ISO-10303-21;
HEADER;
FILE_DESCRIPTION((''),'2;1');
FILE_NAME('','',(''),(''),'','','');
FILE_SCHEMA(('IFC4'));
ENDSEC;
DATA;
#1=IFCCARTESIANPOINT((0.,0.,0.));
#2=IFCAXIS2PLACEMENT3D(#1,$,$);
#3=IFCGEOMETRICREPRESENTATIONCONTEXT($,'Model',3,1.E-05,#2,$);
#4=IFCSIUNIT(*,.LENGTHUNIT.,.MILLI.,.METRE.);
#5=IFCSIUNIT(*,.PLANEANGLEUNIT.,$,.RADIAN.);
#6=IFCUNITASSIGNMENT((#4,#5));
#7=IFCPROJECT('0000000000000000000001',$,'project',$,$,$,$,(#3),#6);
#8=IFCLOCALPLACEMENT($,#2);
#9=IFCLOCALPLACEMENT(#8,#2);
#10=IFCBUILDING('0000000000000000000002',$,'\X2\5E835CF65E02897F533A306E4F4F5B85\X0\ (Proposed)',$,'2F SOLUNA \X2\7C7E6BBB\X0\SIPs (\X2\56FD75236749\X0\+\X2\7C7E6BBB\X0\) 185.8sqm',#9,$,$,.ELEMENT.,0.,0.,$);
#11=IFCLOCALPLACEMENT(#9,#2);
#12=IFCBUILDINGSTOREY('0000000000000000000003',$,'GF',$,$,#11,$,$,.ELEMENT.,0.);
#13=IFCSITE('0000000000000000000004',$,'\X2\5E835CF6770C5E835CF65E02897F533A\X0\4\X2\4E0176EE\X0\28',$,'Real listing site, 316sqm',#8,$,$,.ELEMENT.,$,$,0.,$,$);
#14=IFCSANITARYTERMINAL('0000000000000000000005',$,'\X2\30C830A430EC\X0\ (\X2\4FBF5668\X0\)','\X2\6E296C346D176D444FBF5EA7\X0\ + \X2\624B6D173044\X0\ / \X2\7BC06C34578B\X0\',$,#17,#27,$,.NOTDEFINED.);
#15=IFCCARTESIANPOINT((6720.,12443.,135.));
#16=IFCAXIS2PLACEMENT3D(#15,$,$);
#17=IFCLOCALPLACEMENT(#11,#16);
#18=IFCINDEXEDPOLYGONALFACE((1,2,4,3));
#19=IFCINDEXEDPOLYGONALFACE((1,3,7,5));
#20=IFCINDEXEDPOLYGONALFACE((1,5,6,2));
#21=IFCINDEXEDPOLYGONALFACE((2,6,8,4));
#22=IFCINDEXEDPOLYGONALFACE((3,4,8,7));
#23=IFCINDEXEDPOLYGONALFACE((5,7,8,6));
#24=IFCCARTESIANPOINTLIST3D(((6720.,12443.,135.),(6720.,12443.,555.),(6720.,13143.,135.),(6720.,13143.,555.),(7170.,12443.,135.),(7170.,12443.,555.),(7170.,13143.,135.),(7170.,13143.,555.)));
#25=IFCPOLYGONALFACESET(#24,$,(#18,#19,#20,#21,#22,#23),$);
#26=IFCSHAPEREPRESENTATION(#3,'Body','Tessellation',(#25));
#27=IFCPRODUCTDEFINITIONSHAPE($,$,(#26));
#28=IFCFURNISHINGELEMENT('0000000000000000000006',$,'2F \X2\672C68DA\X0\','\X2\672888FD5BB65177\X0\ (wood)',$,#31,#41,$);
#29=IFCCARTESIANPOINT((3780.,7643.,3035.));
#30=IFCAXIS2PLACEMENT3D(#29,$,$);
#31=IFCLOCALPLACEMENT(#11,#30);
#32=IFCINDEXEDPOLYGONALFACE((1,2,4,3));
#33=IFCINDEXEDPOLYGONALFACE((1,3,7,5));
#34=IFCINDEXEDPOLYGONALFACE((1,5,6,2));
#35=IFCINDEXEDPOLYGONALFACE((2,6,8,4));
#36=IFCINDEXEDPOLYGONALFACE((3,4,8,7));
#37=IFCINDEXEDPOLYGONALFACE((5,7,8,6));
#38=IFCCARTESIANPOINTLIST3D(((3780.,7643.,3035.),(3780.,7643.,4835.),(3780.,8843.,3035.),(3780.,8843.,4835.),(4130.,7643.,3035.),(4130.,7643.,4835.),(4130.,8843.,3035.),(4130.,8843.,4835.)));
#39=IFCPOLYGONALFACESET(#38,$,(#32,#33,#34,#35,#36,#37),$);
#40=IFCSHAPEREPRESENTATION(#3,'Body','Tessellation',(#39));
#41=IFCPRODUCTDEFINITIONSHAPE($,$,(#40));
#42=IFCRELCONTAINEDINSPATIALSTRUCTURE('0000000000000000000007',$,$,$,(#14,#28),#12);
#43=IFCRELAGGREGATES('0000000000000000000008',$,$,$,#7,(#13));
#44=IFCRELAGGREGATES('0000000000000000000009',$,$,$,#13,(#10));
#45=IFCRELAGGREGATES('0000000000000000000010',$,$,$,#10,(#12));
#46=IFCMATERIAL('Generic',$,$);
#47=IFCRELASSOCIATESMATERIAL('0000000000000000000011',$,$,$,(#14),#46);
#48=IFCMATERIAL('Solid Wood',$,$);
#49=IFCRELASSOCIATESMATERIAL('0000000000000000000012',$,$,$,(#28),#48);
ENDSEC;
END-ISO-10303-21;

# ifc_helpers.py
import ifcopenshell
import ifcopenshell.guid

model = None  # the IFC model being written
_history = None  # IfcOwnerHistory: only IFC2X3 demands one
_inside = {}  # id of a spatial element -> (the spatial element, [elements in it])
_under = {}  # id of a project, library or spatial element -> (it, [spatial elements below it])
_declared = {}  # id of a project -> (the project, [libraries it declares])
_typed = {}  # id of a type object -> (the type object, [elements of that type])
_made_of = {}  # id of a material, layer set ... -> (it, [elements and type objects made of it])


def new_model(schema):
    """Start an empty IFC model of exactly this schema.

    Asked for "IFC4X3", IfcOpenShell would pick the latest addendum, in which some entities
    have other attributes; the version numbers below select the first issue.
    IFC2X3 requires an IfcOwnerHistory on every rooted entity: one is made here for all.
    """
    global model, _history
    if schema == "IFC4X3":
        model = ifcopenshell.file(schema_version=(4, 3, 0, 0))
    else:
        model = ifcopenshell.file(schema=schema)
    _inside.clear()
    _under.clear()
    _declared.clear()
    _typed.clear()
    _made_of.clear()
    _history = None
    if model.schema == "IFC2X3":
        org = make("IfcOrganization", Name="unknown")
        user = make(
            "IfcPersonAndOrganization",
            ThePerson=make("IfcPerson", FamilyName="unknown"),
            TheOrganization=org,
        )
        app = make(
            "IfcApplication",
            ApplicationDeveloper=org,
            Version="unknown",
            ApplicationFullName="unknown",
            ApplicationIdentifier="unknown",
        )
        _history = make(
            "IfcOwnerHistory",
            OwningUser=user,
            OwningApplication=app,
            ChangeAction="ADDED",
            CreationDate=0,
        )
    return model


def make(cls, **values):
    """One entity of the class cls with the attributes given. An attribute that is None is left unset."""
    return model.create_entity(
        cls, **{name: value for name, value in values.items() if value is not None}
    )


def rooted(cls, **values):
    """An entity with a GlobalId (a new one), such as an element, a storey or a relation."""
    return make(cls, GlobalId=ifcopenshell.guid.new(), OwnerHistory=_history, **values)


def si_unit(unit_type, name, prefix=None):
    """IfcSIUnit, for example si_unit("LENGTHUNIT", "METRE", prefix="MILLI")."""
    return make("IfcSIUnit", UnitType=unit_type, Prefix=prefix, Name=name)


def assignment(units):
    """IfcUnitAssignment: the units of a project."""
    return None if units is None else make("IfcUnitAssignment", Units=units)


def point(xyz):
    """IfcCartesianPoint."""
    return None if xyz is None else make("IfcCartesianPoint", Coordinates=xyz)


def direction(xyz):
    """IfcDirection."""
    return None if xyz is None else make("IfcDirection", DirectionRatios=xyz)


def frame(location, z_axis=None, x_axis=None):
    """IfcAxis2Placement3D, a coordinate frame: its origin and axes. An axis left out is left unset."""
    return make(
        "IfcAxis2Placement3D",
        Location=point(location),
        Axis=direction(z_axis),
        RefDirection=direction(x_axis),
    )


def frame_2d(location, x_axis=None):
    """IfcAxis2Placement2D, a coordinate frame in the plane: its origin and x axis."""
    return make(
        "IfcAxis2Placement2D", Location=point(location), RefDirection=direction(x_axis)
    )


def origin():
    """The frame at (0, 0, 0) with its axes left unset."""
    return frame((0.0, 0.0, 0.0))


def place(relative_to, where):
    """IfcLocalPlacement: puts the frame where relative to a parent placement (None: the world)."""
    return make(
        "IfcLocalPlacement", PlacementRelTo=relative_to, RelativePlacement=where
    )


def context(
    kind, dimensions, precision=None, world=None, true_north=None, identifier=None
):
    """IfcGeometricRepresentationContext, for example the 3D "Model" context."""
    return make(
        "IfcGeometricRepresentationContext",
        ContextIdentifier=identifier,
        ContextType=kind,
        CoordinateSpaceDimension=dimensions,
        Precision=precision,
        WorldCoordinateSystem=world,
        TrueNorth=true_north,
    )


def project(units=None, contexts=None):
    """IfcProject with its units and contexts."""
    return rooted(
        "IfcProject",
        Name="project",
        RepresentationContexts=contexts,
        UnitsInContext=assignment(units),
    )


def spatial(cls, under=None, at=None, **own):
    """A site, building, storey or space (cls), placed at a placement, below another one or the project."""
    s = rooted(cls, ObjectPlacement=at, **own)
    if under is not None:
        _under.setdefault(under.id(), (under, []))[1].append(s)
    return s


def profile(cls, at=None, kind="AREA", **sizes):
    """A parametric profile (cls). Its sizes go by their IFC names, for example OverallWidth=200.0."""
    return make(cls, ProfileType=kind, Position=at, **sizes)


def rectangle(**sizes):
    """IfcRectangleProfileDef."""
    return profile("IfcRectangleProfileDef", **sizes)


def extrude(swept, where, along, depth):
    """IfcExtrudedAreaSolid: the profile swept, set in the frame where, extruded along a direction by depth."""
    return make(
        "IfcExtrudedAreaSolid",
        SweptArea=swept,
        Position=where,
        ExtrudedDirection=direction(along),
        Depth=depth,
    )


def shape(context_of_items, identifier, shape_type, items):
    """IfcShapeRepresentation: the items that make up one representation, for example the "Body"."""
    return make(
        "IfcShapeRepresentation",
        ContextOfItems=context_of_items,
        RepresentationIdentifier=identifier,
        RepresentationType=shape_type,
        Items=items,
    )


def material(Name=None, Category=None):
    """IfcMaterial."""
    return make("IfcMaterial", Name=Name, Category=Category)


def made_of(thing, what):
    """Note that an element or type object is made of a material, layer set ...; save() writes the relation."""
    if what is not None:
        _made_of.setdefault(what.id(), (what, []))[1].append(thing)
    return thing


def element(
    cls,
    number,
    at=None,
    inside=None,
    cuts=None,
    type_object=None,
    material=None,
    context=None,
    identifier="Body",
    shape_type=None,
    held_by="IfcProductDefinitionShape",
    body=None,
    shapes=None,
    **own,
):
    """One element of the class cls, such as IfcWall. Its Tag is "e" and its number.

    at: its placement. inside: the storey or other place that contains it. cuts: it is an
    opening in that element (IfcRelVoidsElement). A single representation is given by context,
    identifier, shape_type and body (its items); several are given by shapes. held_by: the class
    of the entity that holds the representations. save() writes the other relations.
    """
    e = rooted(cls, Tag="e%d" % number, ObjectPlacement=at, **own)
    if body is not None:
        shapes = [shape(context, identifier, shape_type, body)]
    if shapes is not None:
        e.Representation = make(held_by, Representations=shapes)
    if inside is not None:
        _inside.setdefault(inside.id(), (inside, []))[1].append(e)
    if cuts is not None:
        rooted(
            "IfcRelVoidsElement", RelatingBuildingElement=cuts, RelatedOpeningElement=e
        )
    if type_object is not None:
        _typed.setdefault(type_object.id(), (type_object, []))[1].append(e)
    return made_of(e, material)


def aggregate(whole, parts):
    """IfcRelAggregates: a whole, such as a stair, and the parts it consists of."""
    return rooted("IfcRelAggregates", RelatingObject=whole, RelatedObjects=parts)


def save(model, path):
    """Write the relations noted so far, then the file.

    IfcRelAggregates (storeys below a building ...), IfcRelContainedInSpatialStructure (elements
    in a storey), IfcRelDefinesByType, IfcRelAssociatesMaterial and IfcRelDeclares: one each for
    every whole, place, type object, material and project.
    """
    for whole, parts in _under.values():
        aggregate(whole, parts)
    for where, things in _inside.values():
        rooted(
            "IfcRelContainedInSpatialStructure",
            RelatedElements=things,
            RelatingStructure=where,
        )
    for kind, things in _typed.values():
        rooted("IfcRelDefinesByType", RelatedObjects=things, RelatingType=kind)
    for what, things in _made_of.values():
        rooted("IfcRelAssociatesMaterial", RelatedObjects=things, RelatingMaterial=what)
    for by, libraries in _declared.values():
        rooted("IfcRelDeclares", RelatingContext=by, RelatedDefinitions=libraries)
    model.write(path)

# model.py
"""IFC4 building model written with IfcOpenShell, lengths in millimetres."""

from ifc_helpers import new_model, si_unit, frame, frame_2d, origin, place, context, project, spatial, rectangle, extrude, material, element, save


model = new_model("IFC4")

# Units and contexts
model_context = context("Model", 3, precision=1e-05, world=origin())
ifc_project = project(units=[si_unit("LENGTHUNIT", "METRE", prefix="MILLI"), si_unit("PLANEANGLEUNIT", "RADIAN")], contexts=[model_context])

# Site, building, storey
site_placement = place(None, origin())
site = spatial("IfcSite", under=ifc_project, at=site_placement, Name="広島県広島市西区4丁目28", ObjectType="Real listing site, 316sqm", CompositionType="ELEMENT", RefElevation=0.0)
building_placement = place(site_placement, origin())
building = spatial("IfcBuilding", under=site, at=building_placement, Name="広島市西区の住宅 (Proposed)", ObjectType="2F SOLUNA 籾殻SIPs (国産杉+籾殻) 185.8sqm", CompositionType="ELEMENT", ElevationOfRefHeight=0.0, ElevationOfTerrain=0.0)
storey_placement = place(building_placement, origin())
storey = spatial("IfcBuildingStorey", under=building, at=storey_placement, Name="GF", CompositionType="ELEMENT", Elevation=0.0)

# Shared definitions
ifc_material_1 = material(Name="Solid Wood")
ifc_material_2 = material(Name="Generic")

# Sanitary terminal
sanitary_terminal_1_placement = place(storey_placement, frame((6720.0, 12443.0, 135.0)))
element("IfcSanitaryTerminal", 1, at=sanitary_terminal_1_placement, inside=storey, material=ifc_material_2, Name="トイレ (便器)", Description="温水洗浄便座 + 手洗い / 節水型", PredefinedType="NOTDEFINED", context=model_context, shape_type="SweptSolid", body=[
    extrude(rectangle(XDim=450.0, YDim=700.0, at=frame_2d((225.0, 350.0))), frame((6720.0, 12443.0, 135.0)), (0.0, 0.0, 1.0), 420.0),
])

# Furnishing element
furnishing_placement = place(storey_placement, frame((3780.0, 7643.0, 3035.0)))
element("IfcFurnishingElement", 2, at=furnishing_placement, inside=storey, material=ifc_material_1, Name="2F 本棚", Description="木製家具 (wood)", context=model_context, shape_type="SweptSolid", body=[
    extrude(rectangle(XDim=350.0, YDim=1200.0, at=frame_2d((175.0, 600.0))), frame((3780.0, 7643.0, 3035.0)), (0.0, 0.0, 1.0), 1800.0),
])

save(model, "model.ifc")
